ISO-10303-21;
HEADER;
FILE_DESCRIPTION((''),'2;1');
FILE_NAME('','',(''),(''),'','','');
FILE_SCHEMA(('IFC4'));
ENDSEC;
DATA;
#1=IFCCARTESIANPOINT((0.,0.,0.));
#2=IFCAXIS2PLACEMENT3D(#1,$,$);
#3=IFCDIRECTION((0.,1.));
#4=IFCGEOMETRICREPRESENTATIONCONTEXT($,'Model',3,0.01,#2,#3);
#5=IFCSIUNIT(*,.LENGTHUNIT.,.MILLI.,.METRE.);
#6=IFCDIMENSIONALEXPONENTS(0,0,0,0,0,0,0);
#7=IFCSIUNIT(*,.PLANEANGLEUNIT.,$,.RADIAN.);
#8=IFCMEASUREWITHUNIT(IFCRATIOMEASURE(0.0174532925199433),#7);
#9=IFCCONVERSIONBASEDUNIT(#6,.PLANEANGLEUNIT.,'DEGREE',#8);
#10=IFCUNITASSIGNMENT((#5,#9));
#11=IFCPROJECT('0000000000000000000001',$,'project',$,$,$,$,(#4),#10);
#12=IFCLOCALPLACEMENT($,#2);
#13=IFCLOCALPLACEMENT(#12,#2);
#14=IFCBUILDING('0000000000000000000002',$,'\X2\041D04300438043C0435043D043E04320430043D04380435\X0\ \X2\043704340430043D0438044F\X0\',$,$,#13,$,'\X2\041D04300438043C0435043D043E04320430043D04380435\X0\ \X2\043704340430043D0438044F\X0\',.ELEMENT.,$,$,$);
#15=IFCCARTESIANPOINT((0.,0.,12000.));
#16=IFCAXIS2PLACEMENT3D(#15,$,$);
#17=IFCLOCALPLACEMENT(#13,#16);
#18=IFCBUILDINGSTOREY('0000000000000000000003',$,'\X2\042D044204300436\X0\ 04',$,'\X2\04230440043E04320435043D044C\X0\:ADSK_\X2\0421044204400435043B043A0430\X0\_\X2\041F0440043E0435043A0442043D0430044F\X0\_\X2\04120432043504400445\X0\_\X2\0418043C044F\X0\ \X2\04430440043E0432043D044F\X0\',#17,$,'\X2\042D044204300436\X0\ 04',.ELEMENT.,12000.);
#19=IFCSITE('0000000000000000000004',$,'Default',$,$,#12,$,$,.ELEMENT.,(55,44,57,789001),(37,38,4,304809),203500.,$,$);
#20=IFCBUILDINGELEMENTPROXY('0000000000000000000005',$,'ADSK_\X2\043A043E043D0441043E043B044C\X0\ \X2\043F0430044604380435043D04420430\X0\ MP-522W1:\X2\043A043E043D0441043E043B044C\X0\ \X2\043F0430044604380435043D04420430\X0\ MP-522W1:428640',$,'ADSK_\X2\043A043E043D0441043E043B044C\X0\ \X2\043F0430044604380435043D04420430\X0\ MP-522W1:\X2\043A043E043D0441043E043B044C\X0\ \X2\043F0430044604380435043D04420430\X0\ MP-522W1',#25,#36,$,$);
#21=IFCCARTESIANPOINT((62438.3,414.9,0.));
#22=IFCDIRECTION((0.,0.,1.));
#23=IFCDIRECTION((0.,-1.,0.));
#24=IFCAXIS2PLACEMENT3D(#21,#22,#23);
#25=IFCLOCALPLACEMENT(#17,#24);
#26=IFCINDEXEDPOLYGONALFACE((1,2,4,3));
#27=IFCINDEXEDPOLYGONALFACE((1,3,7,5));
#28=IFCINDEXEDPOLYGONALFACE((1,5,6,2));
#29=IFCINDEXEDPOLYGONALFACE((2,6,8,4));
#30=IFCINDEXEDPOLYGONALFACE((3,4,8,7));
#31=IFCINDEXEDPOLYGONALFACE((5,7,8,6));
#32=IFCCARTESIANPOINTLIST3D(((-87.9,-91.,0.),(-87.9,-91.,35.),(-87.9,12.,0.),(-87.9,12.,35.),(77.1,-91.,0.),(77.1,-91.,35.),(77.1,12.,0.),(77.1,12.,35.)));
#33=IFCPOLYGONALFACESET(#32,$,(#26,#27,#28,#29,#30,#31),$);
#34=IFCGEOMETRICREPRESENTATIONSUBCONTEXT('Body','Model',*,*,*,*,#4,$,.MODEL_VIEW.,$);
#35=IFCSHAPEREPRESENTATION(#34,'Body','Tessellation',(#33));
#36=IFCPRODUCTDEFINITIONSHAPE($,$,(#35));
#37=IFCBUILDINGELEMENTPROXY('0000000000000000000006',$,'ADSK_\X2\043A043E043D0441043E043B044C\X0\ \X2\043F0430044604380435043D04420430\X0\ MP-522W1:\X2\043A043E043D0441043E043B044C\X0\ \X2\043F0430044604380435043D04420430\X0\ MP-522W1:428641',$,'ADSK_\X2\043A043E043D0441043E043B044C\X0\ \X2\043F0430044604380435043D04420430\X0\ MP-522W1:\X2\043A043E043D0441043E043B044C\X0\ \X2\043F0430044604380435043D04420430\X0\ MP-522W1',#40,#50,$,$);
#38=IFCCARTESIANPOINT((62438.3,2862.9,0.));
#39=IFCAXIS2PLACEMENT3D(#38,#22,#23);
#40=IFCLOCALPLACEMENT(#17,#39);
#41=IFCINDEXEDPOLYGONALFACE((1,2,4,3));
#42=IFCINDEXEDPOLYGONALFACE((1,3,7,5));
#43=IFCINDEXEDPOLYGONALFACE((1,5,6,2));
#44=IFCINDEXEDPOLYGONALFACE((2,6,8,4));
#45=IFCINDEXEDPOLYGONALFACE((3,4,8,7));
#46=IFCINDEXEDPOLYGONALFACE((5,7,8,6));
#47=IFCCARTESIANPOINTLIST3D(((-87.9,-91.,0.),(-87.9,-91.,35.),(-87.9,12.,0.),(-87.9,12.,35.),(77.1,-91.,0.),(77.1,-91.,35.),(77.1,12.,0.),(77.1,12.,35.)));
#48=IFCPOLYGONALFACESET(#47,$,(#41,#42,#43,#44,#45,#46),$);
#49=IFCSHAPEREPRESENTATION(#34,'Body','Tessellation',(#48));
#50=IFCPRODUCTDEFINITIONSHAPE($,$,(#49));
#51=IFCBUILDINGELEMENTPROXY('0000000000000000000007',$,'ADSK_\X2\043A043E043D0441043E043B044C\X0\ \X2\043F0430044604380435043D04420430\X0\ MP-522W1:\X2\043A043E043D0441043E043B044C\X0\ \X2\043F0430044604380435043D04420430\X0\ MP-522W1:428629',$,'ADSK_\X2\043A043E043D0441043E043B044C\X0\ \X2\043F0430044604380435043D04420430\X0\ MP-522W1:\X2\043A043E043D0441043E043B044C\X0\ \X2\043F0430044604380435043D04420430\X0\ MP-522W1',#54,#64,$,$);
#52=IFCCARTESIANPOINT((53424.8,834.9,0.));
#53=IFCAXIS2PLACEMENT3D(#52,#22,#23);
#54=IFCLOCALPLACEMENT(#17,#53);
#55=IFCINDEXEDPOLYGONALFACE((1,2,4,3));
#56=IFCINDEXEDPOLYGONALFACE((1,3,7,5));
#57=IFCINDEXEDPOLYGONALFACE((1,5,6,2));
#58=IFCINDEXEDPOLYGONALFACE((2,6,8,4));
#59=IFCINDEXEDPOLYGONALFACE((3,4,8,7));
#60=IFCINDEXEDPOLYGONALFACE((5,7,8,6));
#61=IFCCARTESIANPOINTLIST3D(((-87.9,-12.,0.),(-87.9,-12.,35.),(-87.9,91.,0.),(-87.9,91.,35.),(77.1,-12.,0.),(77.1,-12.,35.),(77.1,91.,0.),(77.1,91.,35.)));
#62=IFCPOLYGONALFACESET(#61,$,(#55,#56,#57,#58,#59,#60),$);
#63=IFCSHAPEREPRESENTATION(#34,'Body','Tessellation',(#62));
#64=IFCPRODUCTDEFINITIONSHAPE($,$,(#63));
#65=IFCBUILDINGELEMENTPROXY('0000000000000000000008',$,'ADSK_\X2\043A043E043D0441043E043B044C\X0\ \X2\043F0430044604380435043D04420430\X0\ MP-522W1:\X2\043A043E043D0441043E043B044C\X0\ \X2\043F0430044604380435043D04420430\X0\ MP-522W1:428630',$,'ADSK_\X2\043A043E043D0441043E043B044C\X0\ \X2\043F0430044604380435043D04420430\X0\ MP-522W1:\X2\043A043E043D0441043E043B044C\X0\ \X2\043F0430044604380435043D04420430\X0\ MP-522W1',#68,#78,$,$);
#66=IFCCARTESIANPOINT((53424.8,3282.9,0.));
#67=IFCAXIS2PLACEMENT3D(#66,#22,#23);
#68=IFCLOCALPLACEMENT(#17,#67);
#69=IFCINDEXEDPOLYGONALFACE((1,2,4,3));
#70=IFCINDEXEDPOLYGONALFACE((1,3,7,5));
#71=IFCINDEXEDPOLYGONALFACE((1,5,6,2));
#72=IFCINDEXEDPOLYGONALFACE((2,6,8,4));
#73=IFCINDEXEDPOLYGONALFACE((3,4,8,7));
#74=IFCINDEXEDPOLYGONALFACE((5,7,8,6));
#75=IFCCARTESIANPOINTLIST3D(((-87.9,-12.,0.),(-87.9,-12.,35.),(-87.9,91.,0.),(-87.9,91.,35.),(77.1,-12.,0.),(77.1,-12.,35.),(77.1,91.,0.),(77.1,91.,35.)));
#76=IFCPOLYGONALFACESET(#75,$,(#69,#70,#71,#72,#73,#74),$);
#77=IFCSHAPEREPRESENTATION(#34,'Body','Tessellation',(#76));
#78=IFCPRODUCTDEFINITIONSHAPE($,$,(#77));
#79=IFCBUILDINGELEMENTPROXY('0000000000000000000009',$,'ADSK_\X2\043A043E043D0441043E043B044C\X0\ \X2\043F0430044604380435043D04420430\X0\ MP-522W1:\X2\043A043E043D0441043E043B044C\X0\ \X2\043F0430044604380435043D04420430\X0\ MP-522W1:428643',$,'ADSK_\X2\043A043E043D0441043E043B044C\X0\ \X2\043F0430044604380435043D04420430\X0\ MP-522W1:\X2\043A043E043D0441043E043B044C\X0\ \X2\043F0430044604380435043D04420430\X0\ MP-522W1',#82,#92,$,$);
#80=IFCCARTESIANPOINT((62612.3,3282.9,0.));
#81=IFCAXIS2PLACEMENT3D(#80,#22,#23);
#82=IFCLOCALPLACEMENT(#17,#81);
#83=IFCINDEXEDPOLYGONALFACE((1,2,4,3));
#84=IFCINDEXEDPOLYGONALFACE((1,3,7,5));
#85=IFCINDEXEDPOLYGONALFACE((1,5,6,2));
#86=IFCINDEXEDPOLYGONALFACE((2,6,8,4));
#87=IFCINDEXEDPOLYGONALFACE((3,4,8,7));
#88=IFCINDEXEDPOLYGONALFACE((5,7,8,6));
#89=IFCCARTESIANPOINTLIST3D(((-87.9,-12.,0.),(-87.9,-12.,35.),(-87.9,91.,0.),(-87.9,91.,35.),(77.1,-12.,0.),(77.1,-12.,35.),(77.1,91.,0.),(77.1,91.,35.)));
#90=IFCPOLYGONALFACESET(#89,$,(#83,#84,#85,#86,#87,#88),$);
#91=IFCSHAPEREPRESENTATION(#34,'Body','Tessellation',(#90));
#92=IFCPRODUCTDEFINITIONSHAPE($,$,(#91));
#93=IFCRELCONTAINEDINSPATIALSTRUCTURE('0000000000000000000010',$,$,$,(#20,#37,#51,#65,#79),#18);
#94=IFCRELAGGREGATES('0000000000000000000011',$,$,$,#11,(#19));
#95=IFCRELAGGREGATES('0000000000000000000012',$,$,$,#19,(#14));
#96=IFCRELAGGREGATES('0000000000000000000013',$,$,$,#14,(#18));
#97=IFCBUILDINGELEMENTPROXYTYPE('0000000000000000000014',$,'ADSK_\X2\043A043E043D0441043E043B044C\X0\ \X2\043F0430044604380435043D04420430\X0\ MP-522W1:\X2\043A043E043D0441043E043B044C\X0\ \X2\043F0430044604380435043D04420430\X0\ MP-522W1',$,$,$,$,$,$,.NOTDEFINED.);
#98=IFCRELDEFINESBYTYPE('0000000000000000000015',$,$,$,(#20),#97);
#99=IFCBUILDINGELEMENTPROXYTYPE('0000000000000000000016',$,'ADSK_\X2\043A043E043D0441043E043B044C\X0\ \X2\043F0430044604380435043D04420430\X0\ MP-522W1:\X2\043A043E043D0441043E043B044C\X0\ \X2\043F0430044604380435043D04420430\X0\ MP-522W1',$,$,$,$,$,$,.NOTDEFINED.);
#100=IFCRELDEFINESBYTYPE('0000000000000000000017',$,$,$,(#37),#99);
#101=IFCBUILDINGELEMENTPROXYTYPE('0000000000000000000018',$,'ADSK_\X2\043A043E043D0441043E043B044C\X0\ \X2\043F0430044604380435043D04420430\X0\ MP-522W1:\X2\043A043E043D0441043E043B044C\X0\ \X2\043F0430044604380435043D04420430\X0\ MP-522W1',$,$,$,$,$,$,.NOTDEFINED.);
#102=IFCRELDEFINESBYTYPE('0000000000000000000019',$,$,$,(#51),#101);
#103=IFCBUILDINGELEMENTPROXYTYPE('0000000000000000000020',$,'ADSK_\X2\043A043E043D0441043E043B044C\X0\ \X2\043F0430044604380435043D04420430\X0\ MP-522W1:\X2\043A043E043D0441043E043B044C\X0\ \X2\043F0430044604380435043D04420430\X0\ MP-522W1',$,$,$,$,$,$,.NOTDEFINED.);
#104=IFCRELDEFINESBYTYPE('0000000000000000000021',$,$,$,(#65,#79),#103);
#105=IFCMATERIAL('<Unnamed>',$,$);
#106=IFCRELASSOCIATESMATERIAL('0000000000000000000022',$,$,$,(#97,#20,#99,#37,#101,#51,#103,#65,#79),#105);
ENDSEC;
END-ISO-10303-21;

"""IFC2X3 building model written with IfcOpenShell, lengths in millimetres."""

from ifc_helpers import new_model, entity, si_unit, converted_unit, direction, frame, origin, origin_2d_with_axis, place, context, subcontext, project, spatial, rectangle, extrude, source, transform, mapped, material, type_object, type_shapes, element, save


model = new_model("IFC2X3")

# Units and contexts
model_context = context("Model", 3, precision=0.01, world=origin(), true_north=direction((0.0, 1.0)))
body_context = subcontext(model_context, "Body", "Model", "MODEL_VIEW")
ifc_project = project(units=[si_unit("LENGTHUNIT", "METRE", prefix="MILLI"), converted_unit("PLANEANGLEUNIT", "DEGREE", entity("IfcRatioMeasure", 0.0174532925199433), si_unit("PLANEANGLEUNIT", "RADIAN"), dimensions=[0, 0, 0, 0, 0, 0, 0])], contexts=[model_context])

# Site, building, storey
site_placement = place(None, origin())
site = spatial("IfcSite", under=ifc_project, at=site_placement, Name="Default", CompositionType="ELEMENT", RefLatitude=(55, 44, 57, 789001), RefLongitude=(37, 38, 4, 304809), RefElevation=203500.0)
building_placement = place(site_placement, origin())
building = spatial("IfcBuilding", under=site, at=building_placement, Name="Наименование здания", LongName="Наименование здания", CompositionType="ELEMENT")
storey_placement = place(building_placement, frame((0.0, 0.0, 12000.0)))
storey = spatial("IfcBuildingStorey", under=building, at=storey_placement, Name="Этаж 04", ObjectType="Уровень:ADSK_Стрелка_Проектная_Вверх_Имя уровня", LongName="Этаж 04", CompositionType="ELEMENT", Elevation=12000.0)

# Building element proxies
ifc_material = material(Name="<Unnamed>")
building_element_proxy_type_1 = type_object("IfcBuildingElementProxyType", Name="ADSK_консоль пациента MP-522W1:консоль пациента MP-522W1", PredefinedType="NOTDEFINED", material=ifc_material)
shared_shape_1 = source(origin(), body_context, "Body", "SweptSolid", [
    extrude(rectangle(XDim=165.0, YDim=103.0, at=origin_2d_with_axis()), frame((-5.4, -39.5, 0.0), z_axis=(0.0, 0.0, 1.0), x_axis=(-1.0, 0.0, 0.0)), (0.0, 0.0, 1.0), 35.0),
])
type_shapes(building_element_proxy_type_1, [shared_shape_1])
proxy_1_placement = place(storey_placement, frame((62438.3, 414.9, 0.0), z_axis=(0.0, 0.0, 1.0), x_axis=(0.0, -1.0, 0.0)))
element("IfcBuildingElementProxy", 1, at=proxy_1_placement, inside=storey, type_object=building_element_proxy_type_1, material=ifc_material, Name="ADSK_консоль пациента MP-522W1:консоль пациента MP-522W1:428640", ObjectType="ADSK_консоль пациента MP-522W1:консоль пациента MP-522W1", context=body_context, shape_type="MappedRepresentation", body=[
    mapped(shared_shape_1, transform((0.0, 0.0, 0.0), scale=1.0)),
])
building_element_proxy_type_2 = type_object("IfcBuildingElementProxyType", Name="ADSK_консоль пациента MP-522W1:консоль пациента MP-522W1", PredefinedType="NOTDEFINED", material=ifc_material)
type_shapes(building_element_proxy_type_2, [shared_shape_1])
proxy_2_placement = place(storey_placement, frame((62438.3, 2862.9, 0.0), z_axis=(0.0, 0.0, 1.0), x_axis=(0.0, -1.0, 0.0)))
element("IfcBuildingElementProxy", 2, at=proxy_2_placement, inside=storey, type_object=building_element_proxy_type_2, material=ifc_material, Name="ADSK_консоль пациента MP-522W1:консоль пациента MP-522W1:428641", ObjectType="ADSK_консоль пациента MP-522W1:консоль пациента MP-522W1", context=body_context, shape_type="MappedRepresentation", body=[
    mapped(shared_shape_1, transform((0.0, 0.0, 0.0), scale=1.0)),
])
building_element_proxy_type_3 = type_object("IfcBuildingElementProxyType", Name="ADSK_консоль пациента MP-522W1:консоль пациента MP-522W1", PredefinedType="NOTDEFINED", material=ifc_material)
shared_shape_2 = source(origin(), body_context, "Body", "SweptSolid", [
    extrude(rectangle(XDim=103.0, YDim=165.0, at=origin_2d_with_axis()), frame((-5.4, 39.5, 0.0), z_axis=(0.0, 0.0, 1.0), x_axis=(0.0, 1.0, 0.0)), (0.0, 0.0, 1.0), 35.0),
])
type_shapes(building_element_proxy_type_3, [shared_shape_2])
proxy_3_placement = place(storey_placement, frame((53424.8, 834.9, 0.0), z_axis=(0.0, 0.0, 1.0), x_axis=(0.0, -1.0, 0.0)))
element("IfcBuildingElementProxy", 3, at=proxy_3_placement, inside=storey, type_object=building_element_proxy_type_3, material=ifc_material, Name="ADSK_консоль пациента MP-522W1:консоль пациента MP-522W1:428629", ObjectType="ADSK_консоль пациента MP-522W1:консоль пациента MP-522W1", context=body_context, shape_type="MappedRepresentation", body=[
    mapped(shared_shape_2, transform((0.0, 0.0, 0.0), scale=1.0)),
])
building_element_proxy_type_4 = type_object("IfcBuildingElementProxyType", Name="ADSK_консоль пациента MP-522W1:консоль пациента MP-522W1", PredefinedType="NOTDEFINED", material=ifc_material)
type_shapes(building_element_proxy_type_4, [shared_shape_2])
for number, where, z_axis, x_axis, name in (
    (4, (53424.8, 3282.9, 0.0), (0.0, 0.0, 1.0), (0.0, -1.0, 0.0), "ADSK_консоль пациента MP-522W1:консоль пациента MP-522W1:428630"),
    (5, (62612.3, 3282.9, 0.0), (0.0, 0.0, 1.0), (0.0, -1.0, 0.0), "ADSK_консоль пациента MP-522W1:консоль пациента MP-522W1:428643"),
):
    element("IfcBuildingElementProxy", number, at=place(storey_placement, frame(where, z_axis=z_axis, x_axis=x_axis)), inside=storey, type_object=building_element_proxy_type_4, material=ifc_material, Name=name, ObjectType="ADSK_консоль пациента MP-522W1:консоль пациента MP-522W1", context=body_context, shape_type="MappedRepresentation", body=[
        mapped(shared_shape_2, transform((0.0, 0.0, 0.0), scale=1.0)),
    ])

save(model, "model.ifc")
